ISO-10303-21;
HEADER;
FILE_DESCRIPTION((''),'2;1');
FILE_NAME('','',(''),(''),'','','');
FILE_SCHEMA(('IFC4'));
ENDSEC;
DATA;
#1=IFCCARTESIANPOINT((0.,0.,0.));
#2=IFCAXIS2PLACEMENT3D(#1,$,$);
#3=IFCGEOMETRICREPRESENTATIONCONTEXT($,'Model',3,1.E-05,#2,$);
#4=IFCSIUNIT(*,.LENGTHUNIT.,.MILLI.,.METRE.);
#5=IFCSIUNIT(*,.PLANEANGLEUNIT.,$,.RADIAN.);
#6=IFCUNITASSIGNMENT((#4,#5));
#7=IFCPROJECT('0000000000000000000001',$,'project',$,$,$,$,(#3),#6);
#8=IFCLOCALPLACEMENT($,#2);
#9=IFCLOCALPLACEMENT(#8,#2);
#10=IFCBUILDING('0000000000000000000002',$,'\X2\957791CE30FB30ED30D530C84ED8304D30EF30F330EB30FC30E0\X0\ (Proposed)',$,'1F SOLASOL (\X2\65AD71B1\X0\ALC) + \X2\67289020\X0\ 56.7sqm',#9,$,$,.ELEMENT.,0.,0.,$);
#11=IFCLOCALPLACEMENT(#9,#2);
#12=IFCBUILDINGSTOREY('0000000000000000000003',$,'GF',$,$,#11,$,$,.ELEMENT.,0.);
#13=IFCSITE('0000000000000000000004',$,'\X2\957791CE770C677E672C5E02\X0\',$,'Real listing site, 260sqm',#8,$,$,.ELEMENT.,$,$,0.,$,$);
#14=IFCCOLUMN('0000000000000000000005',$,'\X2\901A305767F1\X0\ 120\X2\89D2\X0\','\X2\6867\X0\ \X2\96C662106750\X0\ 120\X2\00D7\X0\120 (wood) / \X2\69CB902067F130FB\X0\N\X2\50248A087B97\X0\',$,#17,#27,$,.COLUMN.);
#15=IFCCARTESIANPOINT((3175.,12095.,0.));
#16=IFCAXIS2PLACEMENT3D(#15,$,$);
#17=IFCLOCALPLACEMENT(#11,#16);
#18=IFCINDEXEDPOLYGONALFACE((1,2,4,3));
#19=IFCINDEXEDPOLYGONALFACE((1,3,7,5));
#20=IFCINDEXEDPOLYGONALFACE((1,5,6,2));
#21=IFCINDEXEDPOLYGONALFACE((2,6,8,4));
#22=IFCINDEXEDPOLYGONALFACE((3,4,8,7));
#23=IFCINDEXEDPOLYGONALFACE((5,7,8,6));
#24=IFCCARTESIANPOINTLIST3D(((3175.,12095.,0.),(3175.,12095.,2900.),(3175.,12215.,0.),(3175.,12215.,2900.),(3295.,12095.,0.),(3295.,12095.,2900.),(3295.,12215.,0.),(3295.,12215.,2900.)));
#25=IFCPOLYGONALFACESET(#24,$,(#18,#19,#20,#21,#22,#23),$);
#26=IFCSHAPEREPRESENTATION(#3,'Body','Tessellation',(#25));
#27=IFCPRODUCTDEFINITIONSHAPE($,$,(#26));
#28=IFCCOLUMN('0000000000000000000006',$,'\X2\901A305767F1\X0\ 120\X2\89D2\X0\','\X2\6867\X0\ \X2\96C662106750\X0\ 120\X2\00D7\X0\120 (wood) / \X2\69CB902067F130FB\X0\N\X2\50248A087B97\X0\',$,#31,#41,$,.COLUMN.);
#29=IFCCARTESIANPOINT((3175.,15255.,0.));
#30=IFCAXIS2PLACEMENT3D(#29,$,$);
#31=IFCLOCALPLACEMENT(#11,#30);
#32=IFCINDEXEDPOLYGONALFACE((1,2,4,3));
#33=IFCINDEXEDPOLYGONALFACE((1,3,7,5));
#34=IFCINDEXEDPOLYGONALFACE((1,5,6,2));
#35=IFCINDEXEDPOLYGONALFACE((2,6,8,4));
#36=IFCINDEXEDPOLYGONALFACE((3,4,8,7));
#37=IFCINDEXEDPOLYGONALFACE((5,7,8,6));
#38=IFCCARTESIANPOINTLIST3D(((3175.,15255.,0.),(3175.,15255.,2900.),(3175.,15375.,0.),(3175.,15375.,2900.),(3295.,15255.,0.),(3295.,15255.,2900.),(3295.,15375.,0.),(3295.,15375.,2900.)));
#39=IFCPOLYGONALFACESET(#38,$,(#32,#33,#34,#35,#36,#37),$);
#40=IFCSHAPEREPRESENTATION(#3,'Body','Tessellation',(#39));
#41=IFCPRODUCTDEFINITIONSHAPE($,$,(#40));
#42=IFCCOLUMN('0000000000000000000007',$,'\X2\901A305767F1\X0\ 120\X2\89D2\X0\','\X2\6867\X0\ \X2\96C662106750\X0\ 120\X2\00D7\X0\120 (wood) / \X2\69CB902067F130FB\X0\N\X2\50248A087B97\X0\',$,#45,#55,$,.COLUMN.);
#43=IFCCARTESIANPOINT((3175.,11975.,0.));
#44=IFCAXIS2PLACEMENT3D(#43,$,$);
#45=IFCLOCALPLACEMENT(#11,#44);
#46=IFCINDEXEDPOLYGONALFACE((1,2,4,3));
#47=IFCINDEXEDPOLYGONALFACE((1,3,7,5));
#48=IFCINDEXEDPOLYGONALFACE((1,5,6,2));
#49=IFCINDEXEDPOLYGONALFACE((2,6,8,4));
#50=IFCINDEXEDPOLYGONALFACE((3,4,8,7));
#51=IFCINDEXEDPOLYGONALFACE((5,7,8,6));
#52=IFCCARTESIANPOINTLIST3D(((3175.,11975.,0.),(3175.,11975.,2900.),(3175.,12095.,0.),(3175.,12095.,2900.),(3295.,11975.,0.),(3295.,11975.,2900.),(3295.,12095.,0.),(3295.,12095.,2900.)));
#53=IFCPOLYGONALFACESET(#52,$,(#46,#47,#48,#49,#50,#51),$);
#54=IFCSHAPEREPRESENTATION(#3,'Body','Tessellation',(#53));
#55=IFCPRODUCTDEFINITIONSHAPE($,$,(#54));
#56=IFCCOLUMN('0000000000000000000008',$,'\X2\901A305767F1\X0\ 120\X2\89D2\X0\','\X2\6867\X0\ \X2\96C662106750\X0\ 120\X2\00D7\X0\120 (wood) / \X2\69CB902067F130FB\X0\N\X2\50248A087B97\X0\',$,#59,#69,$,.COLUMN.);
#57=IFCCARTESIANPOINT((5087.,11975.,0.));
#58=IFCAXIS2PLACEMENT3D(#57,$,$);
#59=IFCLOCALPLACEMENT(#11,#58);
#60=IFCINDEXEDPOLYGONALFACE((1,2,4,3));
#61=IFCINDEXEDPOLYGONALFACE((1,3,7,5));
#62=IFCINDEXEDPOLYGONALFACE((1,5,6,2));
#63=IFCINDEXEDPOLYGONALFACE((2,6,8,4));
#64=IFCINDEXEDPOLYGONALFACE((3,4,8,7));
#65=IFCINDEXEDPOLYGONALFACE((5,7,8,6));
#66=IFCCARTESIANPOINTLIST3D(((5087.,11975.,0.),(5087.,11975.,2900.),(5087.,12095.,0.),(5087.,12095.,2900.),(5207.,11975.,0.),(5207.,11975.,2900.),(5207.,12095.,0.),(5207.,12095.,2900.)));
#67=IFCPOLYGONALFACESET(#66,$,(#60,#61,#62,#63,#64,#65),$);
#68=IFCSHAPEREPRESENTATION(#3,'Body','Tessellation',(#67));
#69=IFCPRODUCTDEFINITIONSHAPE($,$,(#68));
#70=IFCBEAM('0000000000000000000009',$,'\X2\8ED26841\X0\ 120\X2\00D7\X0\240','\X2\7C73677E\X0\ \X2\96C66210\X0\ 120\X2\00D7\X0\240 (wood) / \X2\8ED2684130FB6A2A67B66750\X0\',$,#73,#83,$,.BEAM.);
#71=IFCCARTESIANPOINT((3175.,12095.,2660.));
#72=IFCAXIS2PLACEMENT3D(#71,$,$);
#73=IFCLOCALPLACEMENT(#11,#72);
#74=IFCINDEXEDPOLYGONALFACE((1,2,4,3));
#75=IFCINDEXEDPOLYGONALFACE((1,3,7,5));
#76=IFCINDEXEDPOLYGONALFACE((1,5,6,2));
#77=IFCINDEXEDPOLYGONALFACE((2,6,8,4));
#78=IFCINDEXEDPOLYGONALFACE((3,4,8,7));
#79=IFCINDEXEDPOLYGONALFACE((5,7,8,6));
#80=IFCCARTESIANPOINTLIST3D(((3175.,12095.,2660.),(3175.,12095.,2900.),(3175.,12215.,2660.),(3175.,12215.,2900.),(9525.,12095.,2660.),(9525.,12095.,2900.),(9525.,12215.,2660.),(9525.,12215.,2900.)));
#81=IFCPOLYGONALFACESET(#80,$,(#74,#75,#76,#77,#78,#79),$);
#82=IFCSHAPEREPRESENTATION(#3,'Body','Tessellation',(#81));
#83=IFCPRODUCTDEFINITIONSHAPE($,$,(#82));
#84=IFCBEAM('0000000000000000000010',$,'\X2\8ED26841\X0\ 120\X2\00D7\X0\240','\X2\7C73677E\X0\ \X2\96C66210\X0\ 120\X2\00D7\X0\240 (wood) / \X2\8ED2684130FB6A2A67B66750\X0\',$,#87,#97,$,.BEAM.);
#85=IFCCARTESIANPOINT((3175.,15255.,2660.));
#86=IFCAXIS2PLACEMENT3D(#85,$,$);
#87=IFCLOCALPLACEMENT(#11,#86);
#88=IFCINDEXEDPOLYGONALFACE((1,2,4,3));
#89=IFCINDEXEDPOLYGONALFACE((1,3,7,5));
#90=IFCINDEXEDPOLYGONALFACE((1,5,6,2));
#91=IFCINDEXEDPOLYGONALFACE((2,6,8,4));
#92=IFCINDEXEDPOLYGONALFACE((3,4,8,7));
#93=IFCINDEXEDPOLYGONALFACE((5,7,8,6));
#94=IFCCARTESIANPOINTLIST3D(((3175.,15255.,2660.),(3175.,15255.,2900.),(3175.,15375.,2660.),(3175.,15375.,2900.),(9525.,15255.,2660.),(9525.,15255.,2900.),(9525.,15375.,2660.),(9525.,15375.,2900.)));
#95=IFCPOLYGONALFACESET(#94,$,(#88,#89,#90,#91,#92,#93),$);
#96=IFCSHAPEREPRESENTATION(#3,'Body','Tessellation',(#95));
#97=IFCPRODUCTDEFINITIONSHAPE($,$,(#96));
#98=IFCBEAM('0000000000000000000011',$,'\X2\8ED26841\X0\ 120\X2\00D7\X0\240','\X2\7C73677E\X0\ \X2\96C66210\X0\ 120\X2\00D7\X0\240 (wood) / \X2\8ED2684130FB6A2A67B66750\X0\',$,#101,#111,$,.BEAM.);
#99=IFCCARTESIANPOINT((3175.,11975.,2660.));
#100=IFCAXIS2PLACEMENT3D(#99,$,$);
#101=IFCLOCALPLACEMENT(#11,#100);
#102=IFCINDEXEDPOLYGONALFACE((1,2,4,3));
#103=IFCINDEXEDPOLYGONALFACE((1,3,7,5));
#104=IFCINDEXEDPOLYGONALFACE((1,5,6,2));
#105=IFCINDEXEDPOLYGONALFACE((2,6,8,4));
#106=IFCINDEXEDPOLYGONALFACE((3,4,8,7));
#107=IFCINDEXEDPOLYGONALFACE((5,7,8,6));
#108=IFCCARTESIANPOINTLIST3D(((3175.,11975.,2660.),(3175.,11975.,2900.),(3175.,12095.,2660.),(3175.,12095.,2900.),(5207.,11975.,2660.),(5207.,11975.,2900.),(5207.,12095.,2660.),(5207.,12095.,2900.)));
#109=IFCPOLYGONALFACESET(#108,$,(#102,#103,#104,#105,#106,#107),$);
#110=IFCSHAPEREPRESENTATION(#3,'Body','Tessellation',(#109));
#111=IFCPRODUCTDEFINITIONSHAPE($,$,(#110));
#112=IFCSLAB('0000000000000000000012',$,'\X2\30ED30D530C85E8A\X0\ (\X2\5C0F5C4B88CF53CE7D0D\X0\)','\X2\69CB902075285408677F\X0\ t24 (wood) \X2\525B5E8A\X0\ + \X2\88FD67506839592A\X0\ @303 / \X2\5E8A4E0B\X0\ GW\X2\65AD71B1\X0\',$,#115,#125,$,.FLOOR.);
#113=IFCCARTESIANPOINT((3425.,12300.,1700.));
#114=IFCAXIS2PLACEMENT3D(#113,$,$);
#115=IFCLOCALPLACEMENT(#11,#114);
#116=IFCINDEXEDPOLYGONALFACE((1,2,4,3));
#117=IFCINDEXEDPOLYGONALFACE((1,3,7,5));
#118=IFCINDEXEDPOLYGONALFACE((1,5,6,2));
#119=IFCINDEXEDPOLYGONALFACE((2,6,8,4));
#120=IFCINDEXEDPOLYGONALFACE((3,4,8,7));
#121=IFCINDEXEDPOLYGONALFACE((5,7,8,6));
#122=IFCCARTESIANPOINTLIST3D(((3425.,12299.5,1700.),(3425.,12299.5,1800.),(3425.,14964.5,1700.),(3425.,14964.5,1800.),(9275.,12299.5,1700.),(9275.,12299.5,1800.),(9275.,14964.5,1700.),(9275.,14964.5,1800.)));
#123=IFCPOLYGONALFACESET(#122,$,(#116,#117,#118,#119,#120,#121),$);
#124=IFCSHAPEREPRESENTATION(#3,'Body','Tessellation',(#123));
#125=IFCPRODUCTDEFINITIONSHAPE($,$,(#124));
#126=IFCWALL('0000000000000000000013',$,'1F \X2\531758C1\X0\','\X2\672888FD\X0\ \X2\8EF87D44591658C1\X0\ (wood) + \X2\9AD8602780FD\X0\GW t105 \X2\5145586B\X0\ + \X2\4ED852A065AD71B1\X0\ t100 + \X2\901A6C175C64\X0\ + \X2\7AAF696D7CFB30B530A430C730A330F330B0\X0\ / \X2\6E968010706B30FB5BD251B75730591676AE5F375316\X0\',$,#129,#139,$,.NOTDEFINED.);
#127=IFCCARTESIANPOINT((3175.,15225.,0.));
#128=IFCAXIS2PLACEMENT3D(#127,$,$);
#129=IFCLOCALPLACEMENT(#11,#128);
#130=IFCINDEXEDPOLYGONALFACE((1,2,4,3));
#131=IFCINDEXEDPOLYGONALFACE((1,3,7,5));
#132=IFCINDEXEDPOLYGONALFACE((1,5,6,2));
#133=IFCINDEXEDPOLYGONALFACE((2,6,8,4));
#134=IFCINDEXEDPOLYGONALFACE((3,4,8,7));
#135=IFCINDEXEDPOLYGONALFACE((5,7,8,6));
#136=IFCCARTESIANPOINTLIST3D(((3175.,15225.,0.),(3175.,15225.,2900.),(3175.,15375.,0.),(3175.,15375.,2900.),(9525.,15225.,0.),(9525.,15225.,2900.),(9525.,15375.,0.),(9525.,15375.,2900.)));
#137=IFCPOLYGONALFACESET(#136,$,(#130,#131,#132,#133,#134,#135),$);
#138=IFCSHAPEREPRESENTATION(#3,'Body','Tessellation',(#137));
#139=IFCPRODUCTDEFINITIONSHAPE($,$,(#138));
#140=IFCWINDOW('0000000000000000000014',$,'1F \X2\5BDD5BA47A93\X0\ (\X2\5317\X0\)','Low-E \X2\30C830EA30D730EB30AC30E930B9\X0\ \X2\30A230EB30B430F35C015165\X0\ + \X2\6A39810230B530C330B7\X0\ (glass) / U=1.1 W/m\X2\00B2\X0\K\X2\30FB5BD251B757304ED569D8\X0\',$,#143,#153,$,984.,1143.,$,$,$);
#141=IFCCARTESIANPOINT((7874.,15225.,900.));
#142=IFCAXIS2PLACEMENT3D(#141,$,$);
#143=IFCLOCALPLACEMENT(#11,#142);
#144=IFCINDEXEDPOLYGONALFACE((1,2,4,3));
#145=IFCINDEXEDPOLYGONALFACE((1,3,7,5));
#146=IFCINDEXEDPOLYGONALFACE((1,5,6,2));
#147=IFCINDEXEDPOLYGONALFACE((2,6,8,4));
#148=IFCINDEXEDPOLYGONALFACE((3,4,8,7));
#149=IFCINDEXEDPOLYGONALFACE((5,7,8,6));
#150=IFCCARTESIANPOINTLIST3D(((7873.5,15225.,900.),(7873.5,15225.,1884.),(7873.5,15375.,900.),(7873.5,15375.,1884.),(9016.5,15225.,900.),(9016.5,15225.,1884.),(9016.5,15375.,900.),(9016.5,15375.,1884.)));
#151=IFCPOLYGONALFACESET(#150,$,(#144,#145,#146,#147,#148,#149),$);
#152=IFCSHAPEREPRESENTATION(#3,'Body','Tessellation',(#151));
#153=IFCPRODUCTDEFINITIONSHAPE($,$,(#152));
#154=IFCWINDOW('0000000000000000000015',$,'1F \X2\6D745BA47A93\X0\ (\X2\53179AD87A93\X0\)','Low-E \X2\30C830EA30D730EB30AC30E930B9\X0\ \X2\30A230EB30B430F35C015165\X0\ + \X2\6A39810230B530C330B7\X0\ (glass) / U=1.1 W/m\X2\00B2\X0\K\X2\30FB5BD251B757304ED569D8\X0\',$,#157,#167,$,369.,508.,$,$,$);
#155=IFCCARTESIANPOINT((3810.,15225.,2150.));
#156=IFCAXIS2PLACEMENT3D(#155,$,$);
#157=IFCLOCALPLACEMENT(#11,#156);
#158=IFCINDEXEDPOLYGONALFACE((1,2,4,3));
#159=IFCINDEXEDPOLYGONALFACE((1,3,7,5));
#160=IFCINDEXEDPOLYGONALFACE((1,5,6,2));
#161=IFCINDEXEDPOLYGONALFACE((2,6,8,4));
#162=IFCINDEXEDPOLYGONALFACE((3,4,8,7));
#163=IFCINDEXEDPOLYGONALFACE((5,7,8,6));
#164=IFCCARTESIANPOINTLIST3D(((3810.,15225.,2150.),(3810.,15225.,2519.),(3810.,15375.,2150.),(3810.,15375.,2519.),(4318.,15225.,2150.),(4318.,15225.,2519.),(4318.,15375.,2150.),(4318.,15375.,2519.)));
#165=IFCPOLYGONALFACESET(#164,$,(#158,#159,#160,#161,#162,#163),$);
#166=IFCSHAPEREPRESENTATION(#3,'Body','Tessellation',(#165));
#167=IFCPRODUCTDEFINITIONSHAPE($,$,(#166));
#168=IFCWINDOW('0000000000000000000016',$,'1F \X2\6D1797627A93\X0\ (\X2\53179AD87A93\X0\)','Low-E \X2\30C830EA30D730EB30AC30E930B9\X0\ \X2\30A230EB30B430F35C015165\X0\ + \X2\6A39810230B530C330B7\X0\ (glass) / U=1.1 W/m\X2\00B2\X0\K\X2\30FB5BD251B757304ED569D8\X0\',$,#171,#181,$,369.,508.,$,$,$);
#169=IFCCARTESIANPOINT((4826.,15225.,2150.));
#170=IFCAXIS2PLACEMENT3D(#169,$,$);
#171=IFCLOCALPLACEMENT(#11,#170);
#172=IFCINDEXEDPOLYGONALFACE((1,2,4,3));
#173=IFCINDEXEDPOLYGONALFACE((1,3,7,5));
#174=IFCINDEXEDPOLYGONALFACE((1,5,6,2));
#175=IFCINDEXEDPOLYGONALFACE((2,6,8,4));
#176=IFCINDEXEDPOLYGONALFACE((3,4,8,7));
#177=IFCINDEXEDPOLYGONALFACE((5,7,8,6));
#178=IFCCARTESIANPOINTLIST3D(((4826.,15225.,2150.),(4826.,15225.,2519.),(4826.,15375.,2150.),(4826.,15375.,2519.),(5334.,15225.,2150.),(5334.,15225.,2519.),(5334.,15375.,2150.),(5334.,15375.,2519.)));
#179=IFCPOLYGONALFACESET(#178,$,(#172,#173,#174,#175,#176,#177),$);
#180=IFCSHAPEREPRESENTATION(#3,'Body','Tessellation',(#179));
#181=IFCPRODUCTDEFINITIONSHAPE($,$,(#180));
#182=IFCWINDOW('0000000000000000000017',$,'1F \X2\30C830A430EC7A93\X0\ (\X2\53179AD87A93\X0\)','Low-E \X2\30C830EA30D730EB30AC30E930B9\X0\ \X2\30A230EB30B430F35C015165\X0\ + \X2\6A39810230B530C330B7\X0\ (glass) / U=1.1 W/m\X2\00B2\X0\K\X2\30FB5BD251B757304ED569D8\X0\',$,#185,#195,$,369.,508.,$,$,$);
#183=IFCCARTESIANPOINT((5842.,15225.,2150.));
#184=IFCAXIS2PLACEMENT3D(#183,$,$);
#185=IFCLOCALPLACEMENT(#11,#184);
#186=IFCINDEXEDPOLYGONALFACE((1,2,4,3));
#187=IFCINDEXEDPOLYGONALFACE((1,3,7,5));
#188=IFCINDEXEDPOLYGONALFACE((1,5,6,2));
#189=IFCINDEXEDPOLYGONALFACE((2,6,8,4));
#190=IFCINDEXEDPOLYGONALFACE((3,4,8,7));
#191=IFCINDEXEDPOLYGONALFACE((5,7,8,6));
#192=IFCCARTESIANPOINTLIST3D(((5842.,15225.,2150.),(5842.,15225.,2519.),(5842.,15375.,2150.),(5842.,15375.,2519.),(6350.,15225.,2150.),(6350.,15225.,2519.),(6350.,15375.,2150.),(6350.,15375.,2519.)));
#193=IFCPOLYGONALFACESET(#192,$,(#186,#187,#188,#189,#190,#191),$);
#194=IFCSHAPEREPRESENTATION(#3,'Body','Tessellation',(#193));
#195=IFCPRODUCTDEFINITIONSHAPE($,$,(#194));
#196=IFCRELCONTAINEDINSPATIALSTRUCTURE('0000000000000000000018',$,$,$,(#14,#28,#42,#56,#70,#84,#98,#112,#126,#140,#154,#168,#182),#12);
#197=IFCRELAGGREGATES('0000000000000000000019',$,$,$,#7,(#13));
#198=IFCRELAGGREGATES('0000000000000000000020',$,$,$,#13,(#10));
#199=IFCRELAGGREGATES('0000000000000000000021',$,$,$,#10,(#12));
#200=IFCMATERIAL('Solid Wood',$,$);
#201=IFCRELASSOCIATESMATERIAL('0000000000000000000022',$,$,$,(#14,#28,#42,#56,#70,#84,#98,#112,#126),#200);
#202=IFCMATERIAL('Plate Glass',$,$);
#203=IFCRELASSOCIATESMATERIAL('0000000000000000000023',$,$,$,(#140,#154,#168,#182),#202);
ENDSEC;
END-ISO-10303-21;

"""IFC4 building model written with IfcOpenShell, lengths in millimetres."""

from ifc_helpers import new_model, si_unit, frame, frame_2d, origin, place, context, project, spatial, rectangle, extrude, material, element, fill, save


model = new_model("IFC4")

# Units and contexts
model_context = context("Model", 3, precision=1e-05, world=origin())
ifc_project = project(units=[si_unit("LENGTHUNIT", "METRE", prefix="MILLI"), si_unit("PLANEANGLEUNIT", "RADIAN")], contexts=[model_context])

# Site, building, storey
site_placement = place(None, origin())
site = spatial("IfcSite", under=ifc_project, at=site_placement, Name="長野県松本市", ObjectType="Real listing site, 260sqm", CompositionType="ELEMENT", RefElevation=0.0)
building_placement = place(site_placement, origin())
building = spatial("IfcBuilding", under=site, at=building_placement, Name="長野・ロフト付きワンルーム (Proposed)", ObjectType="1F SOLASOL (断熱ALC) + 木造 56.7sqm", CompositionType="ELEMENT", ElevationOfRefHeight=0.0, ElevationOfTerrain=0.0)
storey_placement = place(building_placement, origin())
storey = spatial("IfcBuildingStorey", under=building, at=storey_placement, Name="GF", CompositionType="ELEMENT", Elevation=0.0)

# Columns
ifc_material_1 = material(Name="Solid Wood")
column_1_placement = place(storey_placement, frame((3175.0, 12095.0, 0.0)))
element("IfcColumn", 1, at=column_1_placement, inside=storey, material=ifc_material_1, Name="通し柱 120角", Description="桧 集成材 120×120 (wood) / 構造柱・N値計算", PredefinedType="COLUMN", context=model_context, shape_type="SweptSolid", body=[
    extrude(rectangle(XDim=120.0, YDim=120.0, at=frame_2d((60.0, 60.0))), frame((3175.0, 12095.0, 0.0)), (0.0, 0.0, 1.0), 2900.0),
])
column_2_placement = place(storey_placement, frame((3175.0, 15255.0, 0.0)))
element("IfcColumn", 2, at=column_2_placement, inside=storey, material=ifc_material_1, Name="通し柱 120角", Description="桧 集成材 120×120 (wood) / 構造柱・N値計算", PredefinedType="COLUMN", context=model_context, shape_type="SweptSolid", body=[
    extrude(rectangle(XDim=120.0, YDim=120.0, at=frame_2d((60.0, 60.0))), frame((3175.0, 15255.0, 0.0)), (0.0, 0.0, 1.0), 2900.0),
])
column_3_placement = place(storey_placement, frame((3175.0, 11975.0, 0.0)))
element("IfcColumn", 3, at=column_3_placement, inside=storey, material=ifc_material_1, Name="通し柱 120角", Description="桧 集成材 120×120 (wood) / 構造柱・N値計算", PredefinedType="COLUMN", context=model_context, shape_type="SweptSolid", body=[
    extrude(rectangle(XDim=120.0, YDim=120.0, at=frame_2d((60.0, 60.0))), frame((3175.0, 11975.0, 0.0)), (0.0, 0.0, 1.0), 2900.0),
])
column_4_placement = place(storey_placement, frame((5087.0, 11975.0, 0.0)))
element("IfcColumn", 4, at=column_4_placement, inside=storey, material=ifc_material_1, Name="通し柱 120角", Description="桧 集成材 120×120 (wood) / 構造柱・N値計算", PredefinedType="COLUMN", context=model_context, shape_type="SweptSolid", body=[
    extrude(rectangle(XDim=120.0, YDim=120.0, at=frame_2d((60.0, 60.0))), frame((5087.0, 11975.0, 0.0)), (0.0, 0.0, 1.0), 2900.0),
])

# Beams
beam_1_placement = place(storey_placement, frame((3175.0, 12095.0, 2660.0)))
element("IfcBeam", 5, at=beam_1_placement, inside=storey, material=ifc_material_1, Name="軒桁 120×240", Description="米松 集成 120×240 (wood) / 軒桁・横架材", PredefinedType="BEAM", context=model_context, shape_type="SweptSolid", body=[
    extrude(rectangle(XDim=6350.0, YDim=120.0, at=frame_2d((3175.0, 60.0))), frame((3175.0, 12095.0, 2660.0)), (0.0, 0.0, 1.0), 240.0),
])
beam_2_placement = place(storey_placement, frame((3175.0, 15255.0, 2660.0)))
element("IfcBeam", 6, at=beam_2_placement, inside=storey, material=ifc_material_1, Name="軒桁 120×240", Description="米松 集成 120×240 (wood) / 軒桁・横架材", PredefinedType="BEAM", context=model_context, shape_type="SweptSolid", body=[
    extrude(rectangle(XDim=6350.0, YDim=120.0, at=frame_2d((3175.0, 60.0))), frame((3175.0, 15255.0, 2660.0)), (0.0, 0.0, 1.0), 240.0),
])
beam_3_placement = place(storey_placement, frame((3175.0, 11975.0, 2660.0)))
element("IfcBeam", 7, at=beam_3_placement, inside=storey, material=ifc_material_1, Name="軒桁 120×240", Description="米松 集成 120×240 (wood) / 軒桁・横架材", PredefinedType="BEAM", context=model_context, shape_type="SweptSolid", body=[
    extrude(rectangle(XDim=2032.0, YDim=120.0, at=frame_2d((1016.0, 60.0))), frame((3175.0, 11975.0, 2660.0)), (0.0, 0.0, 1.0), 240.0),
])

# Slab
slab_1_placement = place(storey_placement, frame((3425.0, 12300.0, 1700.0)))
element("IfcSlab", 8, at=slab_1_placement, inside=storey, material=ifc_material_1, Name="ロフト床 (小屋裏収納)", Description="構造用合板 t24 (wood) 剛床 + 製材根太 @303 / 床下 GW断熱", PredefinedType="FLOOR", context=model_context, shape_type="SweptSolid", body=[
    extrude(rectangle(XDim=5850.0, YDim=2665.0, at=frame_2d((2925.0, 1332.0))), frame((3425.0, 12300.0, 1700.0)), (0.0, 0.0, 1.0), 100.0),
])

# Wall, openings, windows
wall_1_placement = place(storey_placement, frame((3175.0, 15225.0, 0.0)))
wall_1 = element("IfcWall", 9, at=wall_1_placement, inside=storey, material=ifc_material_1, Name="1F 北壁", Description="木製 軸組外壁 (wood) + 高性能GW t105 充填 + 付加断熱 t100 + 通気層 + 窯業系サイディング / 準耐火・寒冷地外皮強化", PredefinedType="NOTDEFINED", context=model_context, shape_type="SweptSolid", body=[
    extrude(rectangle(XDim=6350.0, YDim=150.0, at=frame_2d((3175.0, 75.0))), frame((3175.0, 15225.0, 0.0)), (0.0, 0.0, 1.0), 2900.0),
])
opening_1_placement = place(storey_placement, frame((7874.0, 15225.0, 900.0)))
opening_1 = element("IfcOpeningElement", 10, at=opening_1_placement, cuts=wall_1, PredefinedType="NOTDEFINED", context=model_context, shape_type="SweptSolid", body=[
    extrude(rectangle(XDim=1143.0, YDim=150.0, at=frame_2d((571.0, 75.0))), frame((7874.0, 15225.0, 900.0)), (0.0, 0.0, 1.0), 984.0),
])
opening_2_placement = place(storey_placement, frame((3810.0, 15225.0, 2150.0)))
opening_2 = element("IfcOpeningElement", 11, at=opening_2_placement, cuts=wall_1, PredefinedType="NOTDEFINED", context=model_context, shape_type="SweptSolid", body=[
    extrude(rectangle(XDim=508.0, YDim=150.0, at=frame_2d((254.0, 75.0))), frame((3810.0, 15225.0, 2150.0)), (0.0, 0.0, 1.0), 369.0),
])
opening_3_placement = place(storey_placement, frame((4826.0, 15225.0, 2150.0)))
opening_3 = element("IfcOpeningElement", 12, at=opening_3_placement, cuts=wall_1, PredefinedType="NOTDEFINED", context=model_context, shape_type="SweptSolid", body=[
    extrude(rectangle(XDim=508.0, YDim=150.0, at=frame_2d((254.0, 75.0))), frame((4826.0, 15225.0, 2150.0)), (0.0, 0.0, 1.0), 369.0),
])
opening_4_placement = place(storey_placement, frame((5842.0, 15225.0, 2150.0)))
opening_4 = element("IfcOpeningElement", 13, at=opening_4_placement, cuts=wall_1, PredefinedType="NOTDEFINED", context=model_context, shape_type="SweptSolid", body=[
    extrude(rectangle(XDim=508.0, YDim=150.0, at=frame_2d((254.0, 75.0))), frame((5842.0, 15225.0, 2150.0)), (0.0, 0.0, 1.0), 369.0),
])
ifc_material_2 = material(Name="Plate Glass")
window_1_placement = place(storey_placement, frame((7874.0, 15225.0, 900.0)))
window_1 = element("IfcWindow", 14, at=window_1_placement, inside=storey, material=ifc_material_2, Name="1F 寝室窓 (北)", Description="Low-E トリプルガラス アルゴン封入 + 樹脂サッシ (glass) / U=1.1 W/m²K・寒冷地仕様", OverallHeight=984.0, OverallWidth=1143.0, context=model_context, shape_type="SweptSolid", body=[
    extrude(rectangle(XDim=1143.0, YDim=150.0, at=frame_2d((571.0, 75.0))), frame((7874.0, 15225.0, 900.0)), (0.0, 0.0, 1.0), 984.0),
])
fill(opening_1, window_1)
window_2_placement = place(storey_placement, frame((3810.0, 15225.0, 2150.0)))
window_2 = element("IfcWindow", 15, at=window_2_placement, inside=storey, material=ifc_material_2, Name="1F 浴室窓 (北高窓)", Description="Low-E トリプルガラス アルゴン封入 + 樹脂サッシ (glass) / U=1.1 W/m²K・寒冷地仕様", OverallHeight=369.0, OverallWidth=508.0, context=model_context, shape_type="SweptSolid", body=[
    extrude(rectangle(XDim=508.0, YDim=150.0, at=frame_2d((254.0, 75.0))), frame((3810.0, 15225.0, 2150.0)), (0.0, 0.0, 1.0), 369.0),
])
fill(opening_2, window_2)
window_3_placement = place(storey_placement, frame((4826.0, 15225.0, 2150.0)))
window_3 = element("IfcWindow", 16, at=window_3_placement, inside=storey, material=ifc_material_2, Name="1F 洗面窓 (北高窓)", Description="Low-E トリプルガラス アルゴン封入 + 樹脂サッシ (glass) / U=1.1 W/m²K・寒冷地仕様", OverallHeight=369.0, OverallWidth=508.0, context=model_context, shape_type="SweptSolid", body=[
    extrude(rectangle(XDim=508.0, YDim=150.0, at=frame_2d((254.0, 75.0))), frame((4826.0, 15225.0, 2150.0)), (0.0, 0.0, 1.0), 369.0),
])
fill(opening_3, window_3)
window_4_placement = place(storey_placement, frame((5842.0, 15225.0, 2150.0)))
window_4 = element("IfcWindow", 17, at=window_4_placement, inside=storey, material=ifc_material_2, Name="1F トイレ窓 (北高窓)", Description="Low-E トリプルガラス アルゴン封入 + 樹脂サッシ (glass) / U=1.1 W/m²K・寒冷地仕様", OverallHeight=369.0, OverallWidth=508.0, context=model_context, shape_type="SweptSolid", body=[
    extrude(rectangle(XDim=508.0, YDim=150.0, at=frame_2d((254.0, 75.0))), frame((5842.0, 15225.0, 2150.0)), (0.0, 0.0, 1.0), 369.0),
])
fill(opening_4, window_4)

save(model, "model.ifc")
